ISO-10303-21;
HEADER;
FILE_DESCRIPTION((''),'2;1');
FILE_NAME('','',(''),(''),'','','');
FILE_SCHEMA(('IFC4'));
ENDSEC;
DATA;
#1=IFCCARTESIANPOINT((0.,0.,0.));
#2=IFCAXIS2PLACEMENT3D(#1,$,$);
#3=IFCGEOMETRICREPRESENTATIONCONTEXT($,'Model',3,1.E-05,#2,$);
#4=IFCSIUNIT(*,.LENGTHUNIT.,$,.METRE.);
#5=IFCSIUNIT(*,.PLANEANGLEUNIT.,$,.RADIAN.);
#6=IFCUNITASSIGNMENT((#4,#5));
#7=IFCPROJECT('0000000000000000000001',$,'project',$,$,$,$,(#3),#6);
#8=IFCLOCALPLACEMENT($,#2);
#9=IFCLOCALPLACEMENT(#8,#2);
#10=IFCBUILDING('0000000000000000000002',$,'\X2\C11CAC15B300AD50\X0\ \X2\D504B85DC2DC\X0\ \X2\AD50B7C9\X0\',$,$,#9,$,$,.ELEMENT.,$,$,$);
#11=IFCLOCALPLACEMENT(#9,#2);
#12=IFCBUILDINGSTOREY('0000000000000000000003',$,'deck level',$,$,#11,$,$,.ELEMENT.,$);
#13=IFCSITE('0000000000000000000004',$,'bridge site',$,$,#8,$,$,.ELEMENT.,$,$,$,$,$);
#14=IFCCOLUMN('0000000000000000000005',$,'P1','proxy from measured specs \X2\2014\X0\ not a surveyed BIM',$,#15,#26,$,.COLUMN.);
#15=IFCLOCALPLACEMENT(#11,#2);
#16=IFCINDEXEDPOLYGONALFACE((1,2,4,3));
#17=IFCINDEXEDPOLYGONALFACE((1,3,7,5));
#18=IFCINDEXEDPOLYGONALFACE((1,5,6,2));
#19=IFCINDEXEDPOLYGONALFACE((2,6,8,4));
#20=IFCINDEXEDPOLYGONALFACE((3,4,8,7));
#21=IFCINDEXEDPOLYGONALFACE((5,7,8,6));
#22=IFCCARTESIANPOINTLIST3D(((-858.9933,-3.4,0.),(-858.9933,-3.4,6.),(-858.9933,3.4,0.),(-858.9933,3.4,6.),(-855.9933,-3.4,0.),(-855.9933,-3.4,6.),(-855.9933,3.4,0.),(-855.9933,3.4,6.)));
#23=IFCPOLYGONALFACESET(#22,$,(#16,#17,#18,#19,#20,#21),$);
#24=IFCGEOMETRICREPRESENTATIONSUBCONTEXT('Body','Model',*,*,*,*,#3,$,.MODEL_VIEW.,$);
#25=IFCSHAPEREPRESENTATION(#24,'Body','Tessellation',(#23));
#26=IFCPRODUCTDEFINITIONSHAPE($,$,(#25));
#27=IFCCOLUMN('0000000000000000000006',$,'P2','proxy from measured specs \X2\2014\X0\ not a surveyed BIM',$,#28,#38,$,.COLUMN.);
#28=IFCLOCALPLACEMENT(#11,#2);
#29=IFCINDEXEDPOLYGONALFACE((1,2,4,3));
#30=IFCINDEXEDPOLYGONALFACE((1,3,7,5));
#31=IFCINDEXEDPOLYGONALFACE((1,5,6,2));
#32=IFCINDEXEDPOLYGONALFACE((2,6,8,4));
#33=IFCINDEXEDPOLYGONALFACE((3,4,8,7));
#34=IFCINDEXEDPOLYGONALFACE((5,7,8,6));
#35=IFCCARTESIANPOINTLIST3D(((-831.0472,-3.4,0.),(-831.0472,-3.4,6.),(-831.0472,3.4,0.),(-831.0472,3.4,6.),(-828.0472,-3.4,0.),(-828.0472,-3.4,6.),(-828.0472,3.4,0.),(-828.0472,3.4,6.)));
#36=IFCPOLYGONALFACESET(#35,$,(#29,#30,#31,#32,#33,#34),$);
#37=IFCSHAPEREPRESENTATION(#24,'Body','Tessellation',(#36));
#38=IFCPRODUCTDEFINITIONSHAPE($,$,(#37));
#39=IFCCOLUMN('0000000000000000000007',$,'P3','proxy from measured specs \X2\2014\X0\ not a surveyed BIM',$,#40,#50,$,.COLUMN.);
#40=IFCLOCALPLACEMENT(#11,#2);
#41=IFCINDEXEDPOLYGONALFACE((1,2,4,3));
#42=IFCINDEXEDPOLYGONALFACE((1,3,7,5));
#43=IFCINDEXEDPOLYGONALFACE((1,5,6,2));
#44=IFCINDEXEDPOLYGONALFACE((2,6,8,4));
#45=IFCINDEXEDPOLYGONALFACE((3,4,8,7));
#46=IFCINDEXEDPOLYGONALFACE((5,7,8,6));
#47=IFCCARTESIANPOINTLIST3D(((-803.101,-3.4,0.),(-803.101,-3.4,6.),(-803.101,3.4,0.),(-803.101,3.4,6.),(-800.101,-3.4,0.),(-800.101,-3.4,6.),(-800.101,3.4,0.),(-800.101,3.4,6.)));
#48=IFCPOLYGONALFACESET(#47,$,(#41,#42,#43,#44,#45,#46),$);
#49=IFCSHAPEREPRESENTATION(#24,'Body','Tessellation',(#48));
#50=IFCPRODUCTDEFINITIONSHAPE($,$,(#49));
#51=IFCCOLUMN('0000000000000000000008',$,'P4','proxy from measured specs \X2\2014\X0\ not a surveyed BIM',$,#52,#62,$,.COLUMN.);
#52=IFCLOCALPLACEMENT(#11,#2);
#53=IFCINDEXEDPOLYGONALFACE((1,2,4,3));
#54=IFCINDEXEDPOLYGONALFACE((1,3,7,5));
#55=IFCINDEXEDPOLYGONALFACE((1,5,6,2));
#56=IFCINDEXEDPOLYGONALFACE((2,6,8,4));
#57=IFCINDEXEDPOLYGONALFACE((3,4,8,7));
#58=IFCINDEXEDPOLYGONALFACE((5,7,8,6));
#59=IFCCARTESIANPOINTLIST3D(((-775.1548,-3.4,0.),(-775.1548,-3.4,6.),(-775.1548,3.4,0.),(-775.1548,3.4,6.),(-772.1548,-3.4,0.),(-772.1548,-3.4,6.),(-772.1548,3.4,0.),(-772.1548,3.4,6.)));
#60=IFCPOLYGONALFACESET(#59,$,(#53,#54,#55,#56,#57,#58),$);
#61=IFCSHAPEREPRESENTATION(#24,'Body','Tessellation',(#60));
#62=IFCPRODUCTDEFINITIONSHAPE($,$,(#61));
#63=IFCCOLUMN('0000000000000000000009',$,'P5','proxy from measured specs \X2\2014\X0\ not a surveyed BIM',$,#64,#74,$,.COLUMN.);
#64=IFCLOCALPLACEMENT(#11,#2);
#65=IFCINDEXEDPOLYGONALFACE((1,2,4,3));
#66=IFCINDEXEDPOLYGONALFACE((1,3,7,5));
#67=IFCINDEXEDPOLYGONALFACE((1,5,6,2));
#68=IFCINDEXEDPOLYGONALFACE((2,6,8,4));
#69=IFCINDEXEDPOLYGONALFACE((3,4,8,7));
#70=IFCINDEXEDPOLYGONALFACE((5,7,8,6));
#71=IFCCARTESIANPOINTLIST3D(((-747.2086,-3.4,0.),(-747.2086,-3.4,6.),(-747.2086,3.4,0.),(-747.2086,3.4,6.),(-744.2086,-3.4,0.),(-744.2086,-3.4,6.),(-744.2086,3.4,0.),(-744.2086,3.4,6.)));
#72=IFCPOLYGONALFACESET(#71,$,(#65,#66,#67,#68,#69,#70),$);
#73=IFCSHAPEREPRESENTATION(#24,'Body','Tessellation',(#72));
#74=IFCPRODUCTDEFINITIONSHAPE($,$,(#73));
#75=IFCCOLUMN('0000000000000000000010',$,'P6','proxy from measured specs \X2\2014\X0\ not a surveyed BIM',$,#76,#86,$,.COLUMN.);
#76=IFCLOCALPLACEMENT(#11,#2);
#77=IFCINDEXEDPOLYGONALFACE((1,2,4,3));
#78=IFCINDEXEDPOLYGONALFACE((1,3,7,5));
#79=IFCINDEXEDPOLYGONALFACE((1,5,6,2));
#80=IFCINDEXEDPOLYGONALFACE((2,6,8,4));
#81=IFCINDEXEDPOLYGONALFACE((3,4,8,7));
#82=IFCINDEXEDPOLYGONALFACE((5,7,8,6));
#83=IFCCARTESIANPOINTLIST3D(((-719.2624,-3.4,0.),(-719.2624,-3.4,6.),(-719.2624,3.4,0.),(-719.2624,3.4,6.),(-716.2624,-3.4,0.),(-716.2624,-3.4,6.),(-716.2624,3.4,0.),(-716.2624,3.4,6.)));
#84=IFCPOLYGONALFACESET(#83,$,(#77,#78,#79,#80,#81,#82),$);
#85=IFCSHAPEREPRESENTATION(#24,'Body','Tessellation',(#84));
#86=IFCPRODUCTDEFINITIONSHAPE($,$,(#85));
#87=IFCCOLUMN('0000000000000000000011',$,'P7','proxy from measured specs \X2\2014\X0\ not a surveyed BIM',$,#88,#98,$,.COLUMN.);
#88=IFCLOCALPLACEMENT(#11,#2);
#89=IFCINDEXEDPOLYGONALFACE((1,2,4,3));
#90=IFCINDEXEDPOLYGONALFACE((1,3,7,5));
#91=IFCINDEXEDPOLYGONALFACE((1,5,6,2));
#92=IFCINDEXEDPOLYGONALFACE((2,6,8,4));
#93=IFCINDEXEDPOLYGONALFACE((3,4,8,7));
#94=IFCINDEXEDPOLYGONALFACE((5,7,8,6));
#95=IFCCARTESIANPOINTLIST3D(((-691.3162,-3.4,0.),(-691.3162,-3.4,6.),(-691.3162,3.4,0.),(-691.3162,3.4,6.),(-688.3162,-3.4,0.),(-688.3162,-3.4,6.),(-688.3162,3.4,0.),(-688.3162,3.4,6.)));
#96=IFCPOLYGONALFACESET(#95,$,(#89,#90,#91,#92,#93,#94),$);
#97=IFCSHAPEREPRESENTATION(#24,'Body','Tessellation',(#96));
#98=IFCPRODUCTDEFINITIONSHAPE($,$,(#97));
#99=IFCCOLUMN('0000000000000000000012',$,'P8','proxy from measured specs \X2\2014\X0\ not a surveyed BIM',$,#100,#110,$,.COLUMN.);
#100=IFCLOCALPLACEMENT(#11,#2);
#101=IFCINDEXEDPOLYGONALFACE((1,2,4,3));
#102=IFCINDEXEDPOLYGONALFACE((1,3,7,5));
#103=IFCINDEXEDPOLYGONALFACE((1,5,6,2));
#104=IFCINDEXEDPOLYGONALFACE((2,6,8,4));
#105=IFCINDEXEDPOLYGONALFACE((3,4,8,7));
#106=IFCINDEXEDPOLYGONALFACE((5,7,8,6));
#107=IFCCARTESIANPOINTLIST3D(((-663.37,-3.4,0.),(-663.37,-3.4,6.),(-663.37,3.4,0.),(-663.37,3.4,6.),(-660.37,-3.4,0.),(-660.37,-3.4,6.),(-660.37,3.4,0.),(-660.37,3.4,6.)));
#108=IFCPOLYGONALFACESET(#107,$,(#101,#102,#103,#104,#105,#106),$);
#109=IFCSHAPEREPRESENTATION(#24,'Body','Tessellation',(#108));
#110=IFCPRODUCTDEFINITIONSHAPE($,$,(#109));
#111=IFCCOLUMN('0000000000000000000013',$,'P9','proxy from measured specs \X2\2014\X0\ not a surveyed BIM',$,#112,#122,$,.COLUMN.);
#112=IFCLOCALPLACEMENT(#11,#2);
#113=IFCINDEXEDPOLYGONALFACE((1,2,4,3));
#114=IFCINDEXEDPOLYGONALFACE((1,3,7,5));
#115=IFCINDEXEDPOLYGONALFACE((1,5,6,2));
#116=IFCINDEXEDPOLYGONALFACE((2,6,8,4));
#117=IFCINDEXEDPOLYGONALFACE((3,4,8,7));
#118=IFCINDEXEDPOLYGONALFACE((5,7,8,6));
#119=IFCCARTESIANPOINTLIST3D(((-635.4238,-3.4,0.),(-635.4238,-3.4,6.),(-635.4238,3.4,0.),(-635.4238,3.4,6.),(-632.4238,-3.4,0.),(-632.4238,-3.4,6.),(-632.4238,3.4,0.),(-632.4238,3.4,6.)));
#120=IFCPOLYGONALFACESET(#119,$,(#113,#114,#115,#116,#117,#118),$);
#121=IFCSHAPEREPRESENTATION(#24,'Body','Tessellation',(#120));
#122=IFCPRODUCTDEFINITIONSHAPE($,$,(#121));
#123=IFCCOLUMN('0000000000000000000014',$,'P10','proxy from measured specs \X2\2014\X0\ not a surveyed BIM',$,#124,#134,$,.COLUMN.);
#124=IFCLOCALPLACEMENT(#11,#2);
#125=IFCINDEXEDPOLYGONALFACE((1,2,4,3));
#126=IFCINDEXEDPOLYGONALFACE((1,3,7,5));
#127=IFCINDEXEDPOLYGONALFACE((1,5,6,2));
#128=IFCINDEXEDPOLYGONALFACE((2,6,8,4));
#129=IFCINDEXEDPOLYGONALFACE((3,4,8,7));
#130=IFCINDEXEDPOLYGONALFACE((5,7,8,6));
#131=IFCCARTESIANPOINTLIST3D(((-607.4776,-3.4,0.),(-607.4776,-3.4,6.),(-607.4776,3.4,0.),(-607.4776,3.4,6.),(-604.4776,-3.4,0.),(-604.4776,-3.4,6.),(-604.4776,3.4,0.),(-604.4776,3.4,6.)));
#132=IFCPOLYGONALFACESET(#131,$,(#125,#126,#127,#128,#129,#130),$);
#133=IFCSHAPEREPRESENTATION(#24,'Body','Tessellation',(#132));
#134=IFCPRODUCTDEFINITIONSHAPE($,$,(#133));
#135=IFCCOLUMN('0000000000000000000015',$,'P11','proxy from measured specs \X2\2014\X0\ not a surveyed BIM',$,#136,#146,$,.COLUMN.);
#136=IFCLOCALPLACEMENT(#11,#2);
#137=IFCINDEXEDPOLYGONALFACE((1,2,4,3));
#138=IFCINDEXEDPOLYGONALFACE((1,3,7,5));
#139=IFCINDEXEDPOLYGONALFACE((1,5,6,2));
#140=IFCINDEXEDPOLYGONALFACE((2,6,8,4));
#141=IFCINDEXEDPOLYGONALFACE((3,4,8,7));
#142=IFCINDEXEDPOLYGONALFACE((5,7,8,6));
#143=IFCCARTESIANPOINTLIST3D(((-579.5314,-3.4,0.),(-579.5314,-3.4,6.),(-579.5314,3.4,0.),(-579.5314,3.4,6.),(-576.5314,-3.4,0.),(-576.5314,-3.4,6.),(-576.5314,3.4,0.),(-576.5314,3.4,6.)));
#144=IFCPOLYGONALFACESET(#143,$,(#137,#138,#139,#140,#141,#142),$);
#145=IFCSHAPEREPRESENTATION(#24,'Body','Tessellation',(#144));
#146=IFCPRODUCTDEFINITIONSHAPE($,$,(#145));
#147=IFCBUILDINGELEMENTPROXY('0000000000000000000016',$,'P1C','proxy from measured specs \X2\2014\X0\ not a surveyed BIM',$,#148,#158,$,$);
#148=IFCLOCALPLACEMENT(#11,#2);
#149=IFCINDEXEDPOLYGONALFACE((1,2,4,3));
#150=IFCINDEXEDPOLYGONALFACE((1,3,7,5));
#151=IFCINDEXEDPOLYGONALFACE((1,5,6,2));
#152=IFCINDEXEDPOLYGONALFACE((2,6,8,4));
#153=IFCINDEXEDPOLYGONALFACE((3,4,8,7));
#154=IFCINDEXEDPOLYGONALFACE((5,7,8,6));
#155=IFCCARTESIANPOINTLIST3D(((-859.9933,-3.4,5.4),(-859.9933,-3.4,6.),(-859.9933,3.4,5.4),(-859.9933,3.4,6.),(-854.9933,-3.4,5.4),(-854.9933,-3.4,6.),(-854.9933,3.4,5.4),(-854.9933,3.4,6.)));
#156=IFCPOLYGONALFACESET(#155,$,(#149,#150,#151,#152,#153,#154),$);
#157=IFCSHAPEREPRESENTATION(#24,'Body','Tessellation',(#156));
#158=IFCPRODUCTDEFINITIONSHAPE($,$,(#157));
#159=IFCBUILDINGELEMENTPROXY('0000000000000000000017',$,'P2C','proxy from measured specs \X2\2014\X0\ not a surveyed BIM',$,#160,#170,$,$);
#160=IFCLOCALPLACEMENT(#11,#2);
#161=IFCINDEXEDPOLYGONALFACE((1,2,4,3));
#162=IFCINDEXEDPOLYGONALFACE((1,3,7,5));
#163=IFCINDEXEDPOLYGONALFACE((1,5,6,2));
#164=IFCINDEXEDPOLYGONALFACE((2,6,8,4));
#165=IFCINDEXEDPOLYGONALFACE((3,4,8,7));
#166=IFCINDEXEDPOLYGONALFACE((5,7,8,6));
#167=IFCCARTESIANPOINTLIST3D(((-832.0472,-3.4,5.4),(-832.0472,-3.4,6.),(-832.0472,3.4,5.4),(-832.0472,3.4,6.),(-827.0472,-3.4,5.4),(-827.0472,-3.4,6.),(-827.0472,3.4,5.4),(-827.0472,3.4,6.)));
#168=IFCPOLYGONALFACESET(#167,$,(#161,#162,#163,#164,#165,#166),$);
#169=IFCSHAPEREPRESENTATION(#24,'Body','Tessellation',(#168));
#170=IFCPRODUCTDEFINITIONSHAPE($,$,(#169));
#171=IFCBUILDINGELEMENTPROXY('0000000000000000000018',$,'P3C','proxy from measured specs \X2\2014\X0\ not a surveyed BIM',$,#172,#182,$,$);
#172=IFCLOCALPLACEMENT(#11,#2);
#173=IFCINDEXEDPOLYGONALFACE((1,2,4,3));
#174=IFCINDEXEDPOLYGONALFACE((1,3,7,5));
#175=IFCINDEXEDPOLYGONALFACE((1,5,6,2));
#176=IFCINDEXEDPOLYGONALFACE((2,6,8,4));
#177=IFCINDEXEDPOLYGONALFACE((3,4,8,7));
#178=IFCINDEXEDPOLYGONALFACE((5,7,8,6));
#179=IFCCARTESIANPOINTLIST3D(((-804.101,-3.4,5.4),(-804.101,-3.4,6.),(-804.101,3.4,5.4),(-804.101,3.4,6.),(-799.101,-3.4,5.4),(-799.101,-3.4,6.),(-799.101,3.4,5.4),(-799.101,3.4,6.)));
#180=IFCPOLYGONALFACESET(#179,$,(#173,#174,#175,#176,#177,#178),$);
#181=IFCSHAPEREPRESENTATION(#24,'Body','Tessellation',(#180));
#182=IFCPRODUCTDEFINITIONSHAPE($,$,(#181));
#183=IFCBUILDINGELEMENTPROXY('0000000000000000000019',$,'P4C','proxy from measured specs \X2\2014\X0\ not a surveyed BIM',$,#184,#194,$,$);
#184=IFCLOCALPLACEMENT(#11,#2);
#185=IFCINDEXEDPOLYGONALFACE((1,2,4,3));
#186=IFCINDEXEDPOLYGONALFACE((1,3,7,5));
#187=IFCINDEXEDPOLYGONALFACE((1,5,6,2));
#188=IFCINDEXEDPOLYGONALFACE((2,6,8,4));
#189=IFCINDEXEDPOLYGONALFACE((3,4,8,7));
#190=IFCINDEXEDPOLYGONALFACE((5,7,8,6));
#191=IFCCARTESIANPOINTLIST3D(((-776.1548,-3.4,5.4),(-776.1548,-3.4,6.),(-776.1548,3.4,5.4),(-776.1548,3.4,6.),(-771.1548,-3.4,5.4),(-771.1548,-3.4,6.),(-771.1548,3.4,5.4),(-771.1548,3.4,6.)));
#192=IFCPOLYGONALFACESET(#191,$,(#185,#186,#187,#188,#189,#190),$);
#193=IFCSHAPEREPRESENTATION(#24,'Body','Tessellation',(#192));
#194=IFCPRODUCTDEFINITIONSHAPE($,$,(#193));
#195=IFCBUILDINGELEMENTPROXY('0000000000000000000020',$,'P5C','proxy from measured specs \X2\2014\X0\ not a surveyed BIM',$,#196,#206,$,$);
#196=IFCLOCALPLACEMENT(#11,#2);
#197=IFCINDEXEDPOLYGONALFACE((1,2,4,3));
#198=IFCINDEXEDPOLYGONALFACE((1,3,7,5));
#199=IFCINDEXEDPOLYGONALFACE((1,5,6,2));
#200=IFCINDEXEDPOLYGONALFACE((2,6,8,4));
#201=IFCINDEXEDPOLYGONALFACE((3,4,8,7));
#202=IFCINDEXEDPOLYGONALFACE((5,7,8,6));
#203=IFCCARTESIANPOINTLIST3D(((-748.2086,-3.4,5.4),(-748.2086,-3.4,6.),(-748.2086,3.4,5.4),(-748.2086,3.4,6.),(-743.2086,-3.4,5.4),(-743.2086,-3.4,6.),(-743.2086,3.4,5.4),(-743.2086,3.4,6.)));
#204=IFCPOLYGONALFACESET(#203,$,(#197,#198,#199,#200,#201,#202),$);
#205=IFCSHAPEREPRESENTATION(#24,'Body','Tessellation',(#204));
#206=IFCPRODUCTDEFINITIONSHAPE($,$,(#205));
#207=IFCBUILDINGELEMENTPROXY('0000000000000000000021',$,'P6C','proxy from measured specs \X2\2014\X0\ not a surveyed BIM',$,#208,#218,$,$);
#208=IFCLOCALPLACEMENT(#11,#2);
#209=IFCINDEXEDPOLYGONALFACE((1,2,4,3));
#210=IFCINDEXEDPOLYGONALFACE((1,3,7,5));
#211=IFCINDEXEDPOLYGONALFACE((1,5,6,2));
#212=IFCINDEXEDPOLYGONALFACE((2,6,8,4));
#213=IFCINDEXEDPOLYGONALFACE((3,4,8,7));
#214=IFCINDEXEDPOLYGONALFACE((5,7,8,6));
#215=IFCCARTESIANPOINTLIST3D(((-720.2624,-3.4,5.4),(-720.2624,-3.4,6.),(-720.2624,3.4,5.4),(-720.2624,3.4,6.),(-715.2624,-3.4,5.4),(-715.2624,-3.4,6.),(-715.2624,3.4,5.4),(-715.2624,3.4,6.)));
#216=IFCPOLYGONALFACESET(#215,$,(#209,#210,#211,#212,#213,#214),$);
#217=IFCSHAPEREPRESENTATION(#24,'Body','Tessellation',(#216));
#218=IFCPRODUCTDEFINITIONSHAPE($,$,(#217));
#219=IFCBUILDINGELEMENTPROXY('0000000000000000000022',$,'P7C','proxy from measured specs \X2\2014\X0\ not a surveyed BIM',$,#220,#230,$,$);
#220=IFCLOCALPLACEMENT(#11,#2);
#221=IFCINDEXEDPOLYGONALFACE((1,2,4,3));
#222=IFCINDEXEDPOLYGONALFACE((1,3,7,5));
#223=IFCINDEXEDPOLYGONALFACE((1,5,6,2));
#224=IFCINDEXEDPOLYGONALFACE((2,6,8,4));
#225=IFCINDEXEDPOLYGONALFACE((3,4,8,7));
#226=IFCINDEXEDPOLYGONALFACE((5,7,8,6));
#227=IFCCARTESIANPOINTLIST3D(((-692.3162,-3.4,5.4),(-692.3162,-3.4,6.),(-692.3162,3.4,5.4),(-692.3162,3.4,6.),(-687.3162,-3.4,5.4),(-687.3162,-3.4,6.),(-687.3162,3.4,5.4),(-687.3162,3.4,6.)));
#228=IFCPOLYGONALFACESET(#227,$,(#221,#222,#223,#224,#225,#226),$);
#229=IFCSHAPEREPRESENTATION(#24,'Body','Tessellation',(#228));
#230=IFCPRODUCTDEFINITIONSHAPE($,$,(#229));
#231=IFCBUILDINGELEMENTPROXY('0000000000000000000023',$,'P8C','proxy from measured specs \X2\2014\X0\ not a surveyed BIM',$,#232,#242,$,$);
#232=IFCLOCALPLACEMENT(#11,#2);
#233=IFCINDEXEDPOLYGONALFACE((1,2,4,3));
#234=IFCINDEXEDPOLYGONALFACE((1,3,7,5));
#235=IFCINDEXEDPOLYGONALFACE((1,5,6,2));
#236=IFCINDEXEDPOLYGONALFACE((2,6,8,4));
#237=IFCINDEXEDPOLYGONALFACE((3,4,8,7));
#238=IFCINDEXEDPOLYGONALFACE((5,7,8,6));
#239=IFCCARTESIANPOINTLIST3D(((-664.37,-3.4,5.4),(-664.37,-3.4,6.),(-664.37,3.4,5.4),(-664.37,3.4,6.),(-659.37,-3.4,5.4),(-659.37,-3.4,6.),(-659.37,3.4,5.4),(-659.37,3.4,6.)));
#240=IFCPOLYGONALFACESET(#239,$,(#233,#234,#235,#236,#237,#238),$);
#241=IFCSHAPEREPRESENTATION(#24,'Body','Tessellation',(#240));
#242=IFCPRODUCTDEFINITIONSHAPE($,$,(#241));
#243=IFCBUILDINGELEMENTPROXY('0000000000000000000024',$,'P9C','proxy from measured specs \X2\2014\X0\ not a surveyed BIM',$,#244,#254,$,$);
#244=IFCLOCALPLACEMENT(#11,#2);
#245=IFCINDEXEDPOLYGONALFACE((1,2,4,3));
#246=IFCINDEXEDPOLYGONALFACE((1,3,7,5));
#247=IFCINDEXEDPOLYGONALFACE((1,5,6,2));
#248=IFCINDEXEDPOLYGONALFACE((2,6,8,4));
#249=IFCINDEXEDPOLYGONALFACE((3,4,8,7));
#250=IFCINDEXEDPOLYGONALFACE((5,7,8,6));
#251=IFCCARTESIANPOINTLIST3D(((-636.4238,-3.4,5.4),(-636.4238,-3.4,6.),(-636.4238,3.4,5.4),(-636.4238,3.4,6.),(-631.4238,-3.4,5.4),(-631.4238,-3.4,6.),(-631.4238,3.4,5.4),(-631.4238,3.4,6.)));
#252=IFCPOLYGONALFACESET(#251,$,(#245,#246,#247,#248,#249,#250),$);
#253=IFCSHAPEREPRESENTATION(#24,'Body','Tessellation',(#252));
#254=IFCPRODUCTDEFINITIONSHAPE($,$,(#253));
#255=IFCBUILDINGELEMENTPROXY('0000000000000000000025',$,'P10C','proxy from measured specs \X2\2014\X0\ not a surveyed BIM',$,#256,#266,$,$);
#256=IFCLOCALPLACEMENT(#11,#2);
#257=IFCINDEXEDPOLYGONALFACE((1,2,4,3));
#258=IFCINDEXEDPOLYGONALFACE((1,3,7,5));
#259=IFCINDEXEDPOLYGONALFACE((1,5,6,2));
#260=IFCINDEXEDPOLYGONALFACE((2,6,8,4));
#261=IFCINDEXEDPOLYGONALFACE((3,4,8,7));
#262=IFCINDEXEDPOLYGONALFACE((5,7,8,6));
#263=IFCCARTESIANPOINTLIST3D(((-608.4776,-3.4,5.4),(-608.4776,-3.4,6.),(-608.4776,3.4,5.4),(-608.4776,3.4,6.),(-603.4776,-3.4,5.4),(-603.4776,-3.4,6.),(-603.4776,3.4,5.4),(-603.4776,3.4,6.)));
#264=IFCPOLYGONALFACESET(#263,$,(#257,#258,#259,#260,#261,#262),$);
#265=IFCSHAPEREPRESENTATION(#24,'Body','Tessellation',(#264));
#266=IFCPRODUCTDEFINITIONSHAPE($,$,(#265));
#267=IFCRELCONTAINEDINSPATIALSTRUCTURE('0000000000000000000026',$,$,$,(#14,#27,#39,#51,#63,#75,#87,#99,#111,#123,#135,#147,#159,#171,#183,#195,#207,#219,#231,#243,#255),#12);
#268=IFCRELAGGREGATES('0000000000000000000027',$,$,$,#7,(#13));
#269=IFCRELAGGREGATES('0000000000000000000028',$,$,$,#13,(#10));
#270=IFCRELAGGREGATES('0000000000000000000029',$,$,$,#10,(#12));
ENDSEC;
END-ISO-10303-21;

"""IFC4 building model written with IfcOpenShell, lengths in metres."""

from ifc_helpers import new_model, si_unit, frame, origin, origin_2d, place, context, subcontext, project, spatial, rectangle, extrude, element, save


model = new_model("IFC4")

# Units and contexts
model_context = context("Model", 3, precision=1e-05, world=origin())
body_context = subcontext(model_context, "Body", "Model", "MODEL_VIEW")
ifc_project = project(units=[si_unit("LENGTHUNIT", "METRE"), si_unit("PLANEANGLEUNIT", "RADIAN")], contexts=[model_context])

# Site, building, storey
site_placement = place(None, origin())
site = spatial("IfcSite", under=ifc_project, at=site_placement, Name="bridge site", CompositionType="ELEMENT")
building_placement = place(site_placement, origin())
building = spatial("IfcBuilding", under=site, at=building_placement, Name="서강대교 프록시 교량", CompositionType="ELEMENT")
storey_placement = place(building_placement, origin())
storey = spatial("IfcBuildingStorey", under=building, at=storey_placement, Name="deck level", CompositionType="ELEMENT")

# Columns
for number, where, name in (
    (1, (-857.4933, 0.0, 0.0), "P1"),
    (2, (-829.5472, 0.0, 0.0), "P2"),
    (3, (-801.601, 0.0, 0.0), "P3"),
    (4, (-773.6548, 0.0, 0.0), "P4"),
    (5, (-745.7086, 0.0, 0.0), "P5"),
    (6, (-717.7624, 0.0, 0.0), "P6"),
    (7, (-689.8162, 0.0, 0.0), "P7"),
    (8, (-661.87, 0.0, 0.0), "P8"),
    (9, (-633.9238, 0.0, 0.0), "P9"),
    (10, (-605.9776, 0.0, 0.0), "P10"),
    (11, (-578.0314, 0.0, 0.0), "P11"),
):
    element("IfcColumn", number, at=place(storey_placement, frame(where)), inside=storey, Name=name, Description="proxy from measured specs — not a surveyed BIM", PredefinedType="COLUMN", context=body_context, shape_type="SweptSolid", body=[
        extrude(rectangle(XDim=3.0, YDim=6.8, at=origin_2d()), origin(), (0.0, 0.0, 1.0), 6.0),
    ])

# Building element proxies
for number, where, name in (
    (12, (-857.4933, 0.0, 5.4), "P1C"),
    (13, (-829.5472, 0.0, 5.4), "P2C"),
    (14, (-801.601, 0.0, 5.4), "P3C"),
    (15, (-773.6548, 0.0, 5.4), "P4C"),
    (16, (-745.7086, 0.0, 5.4), "P5C"),
    (17, (-717.7624, 0.0, 5.4), "P6C"),
    (18, (-689.8162, 0.0, 5.4), "P7C"),
    (19, (-661.87, 0.0, 5.4), "P8C"),
    (20, (-633.9238, 0.0, 5.4), "P9C"),
    (21, (-605.9776, 0.0, 5.4), "P10C"),
):
    element("IfcBuildingElementProxy", number, at=place(storey_placement, frame(where)), inside=storey, Name=name, Description="proxy from measured specs — not a surveyed BIM", context=body_context, shape_type="SweptSolid", body=[
        extrude(rectangle(XDim=5.0, YDim=6.8, at=origin_2d()), origin(), (0.0, 0.0, 1.0), 0.6),
    ])

save(model, "model.ifc")
